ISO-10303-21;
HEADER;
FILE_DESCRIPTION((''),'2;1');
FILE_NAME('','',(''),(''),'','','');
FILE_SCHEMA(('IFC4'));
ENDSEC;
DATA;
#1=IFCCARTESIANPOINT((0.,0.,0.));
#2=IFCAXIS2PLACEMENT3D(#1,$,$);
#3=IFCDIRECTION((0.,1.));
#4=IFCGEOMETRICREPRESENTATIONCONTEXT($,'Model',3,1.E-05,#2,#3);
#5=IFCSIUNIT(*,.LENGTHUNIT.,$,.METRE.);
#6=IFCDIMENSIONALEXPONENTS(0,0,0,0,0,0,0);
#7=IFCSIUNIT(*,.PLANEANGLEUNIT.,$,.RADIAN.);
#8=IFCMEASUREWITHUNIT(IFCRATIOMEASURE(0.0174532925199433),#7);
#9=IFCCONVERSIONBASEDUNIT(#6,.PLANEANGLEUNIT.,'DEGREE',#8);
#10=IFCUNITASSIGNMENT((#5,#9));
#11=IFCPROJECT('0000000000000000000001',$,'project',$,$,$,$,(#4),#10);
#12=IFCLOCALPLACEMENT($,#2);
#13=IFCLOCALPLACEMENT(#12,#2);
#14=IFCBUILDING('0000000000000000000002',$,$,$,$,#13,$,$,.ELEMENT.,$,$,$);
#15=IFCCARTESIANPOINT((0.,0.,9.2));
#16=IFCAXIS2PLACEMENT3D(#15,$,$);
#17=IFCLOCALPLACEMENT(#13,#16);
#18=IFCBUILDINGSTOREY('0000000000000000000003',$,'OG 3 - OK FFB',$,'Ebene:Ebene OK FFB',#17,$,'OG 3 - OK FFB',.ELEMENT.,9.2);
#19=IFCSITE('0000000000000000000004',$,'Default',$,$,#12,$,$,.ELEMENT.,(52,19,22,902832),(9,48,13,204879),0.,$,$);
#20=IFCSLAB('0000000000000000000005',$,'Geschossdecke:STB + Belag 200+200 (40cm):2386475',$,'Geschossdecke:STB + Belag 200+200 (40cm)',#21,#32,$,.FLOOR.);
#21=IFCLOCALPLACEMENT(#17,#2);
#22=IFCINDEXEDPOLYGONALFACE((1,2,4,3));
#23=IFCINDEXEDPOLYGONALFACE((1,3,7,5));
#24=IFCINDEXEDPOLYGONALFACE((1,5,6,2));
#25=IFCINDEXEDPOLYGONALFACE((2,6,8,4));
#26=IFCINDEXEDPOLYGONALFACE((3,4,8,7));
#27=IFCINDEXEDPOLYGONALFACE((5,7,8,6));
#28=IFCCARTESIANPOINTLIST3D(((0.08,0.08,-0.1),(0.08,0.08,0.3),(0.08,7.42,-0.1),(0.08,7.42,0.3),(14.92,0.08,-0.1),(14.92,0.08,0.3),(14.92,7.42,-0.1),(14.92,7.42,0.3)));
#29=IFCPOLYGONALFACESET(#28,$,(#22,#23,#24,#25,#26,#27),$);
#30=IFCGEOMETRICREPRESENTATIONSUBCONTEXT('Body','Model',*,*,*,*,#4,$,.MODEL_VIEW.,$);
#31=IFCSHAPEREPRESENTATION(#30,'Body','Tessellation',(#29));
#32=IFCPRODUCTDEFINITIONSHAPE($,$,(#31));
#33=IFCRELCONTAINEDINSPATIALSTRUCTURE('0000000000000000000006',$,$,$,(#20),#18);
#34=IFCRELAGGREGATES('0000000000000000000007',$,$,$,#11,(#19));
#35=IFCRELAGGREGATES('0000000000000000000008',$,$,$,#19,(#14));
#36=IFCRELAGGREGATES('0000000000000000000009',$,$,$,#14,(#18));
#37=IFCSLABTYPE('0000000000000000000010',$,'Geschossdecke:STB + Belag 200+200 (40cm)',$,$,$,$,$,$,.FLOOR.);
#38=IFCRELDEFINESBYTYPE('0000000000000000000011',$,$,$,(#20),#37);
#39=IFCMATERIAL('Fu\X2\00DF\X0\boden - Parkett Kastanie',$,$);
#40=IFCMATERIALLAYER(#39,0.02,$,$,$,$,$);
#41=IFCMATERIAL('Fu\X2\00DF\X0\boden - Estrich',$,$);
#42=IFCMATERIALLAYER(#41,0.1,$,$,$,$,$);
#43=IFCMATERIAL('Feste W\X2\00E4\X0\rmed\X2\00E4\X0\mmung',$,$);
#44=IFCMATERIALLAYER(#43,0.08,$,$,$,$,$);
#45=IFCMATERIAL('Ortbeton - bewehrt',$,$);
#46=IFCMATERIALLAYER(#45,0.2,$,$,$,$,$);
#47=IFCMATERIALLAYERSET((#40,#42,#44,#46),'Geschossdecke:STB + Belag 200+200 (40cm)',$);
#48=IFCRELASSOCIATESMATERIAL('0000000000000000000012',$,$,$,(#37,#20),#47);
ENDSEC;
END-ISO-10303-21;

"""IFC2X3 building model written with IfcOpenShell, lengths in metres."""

from ifc_helpers import new_model, entity, si_unit, converted_unit, direction, frame, frame_2d, origin, place, context, subcontext, project, spatial, rectangle, extrude, material, layer, layer_set, layer_usage, type_object, element, save


model = new_model("IFC2X3")

# Units and contexts
model_context = context("Model", 3, precision=1e-05, world=origin(), true_north=direction((0.0, 1.0)))
body_context = subcontext(model_context, "Body", "Model", "MODEL_VIEW")
ifc_project = project(units=[si_unit("LENGTHUNIT", "METRE"), converted_unit("PLANEANGLEUNIT", "DEGREE", entity("IfcRatioMeasure", 0.0174532925199433), si_unit("PLANEANGLEUNIT", "RADIAN"), dimensions=[0, 0, 0, 0, 0, 0, 0])], contexts=[model_context])

# Site, building, storey
site_placement = place(None, frame((0.0, 0.0, 0.0)))
site = spatial("IfcSite", under=ifc_project, at=site_placement, Name="Default", CompositionType="ELEMENT", RefLatitude=(52, 19, 22, 902832), RefLongitude=(9, 48, 13, 204879), RefElevation=0.0)
building_placement = place(site_placement, origin())
building = spatial("IfcBuilding", under=site, at=building_placement, CompositionType="ELEMENT")
storey_placement = place(building_placement, frame((0.0, 0.0, 9.2)))
storey = spatial("IfcBuildingStorey", under=building, at=storey_placement, Name="OG 3 - OK FFB", ObjectType="Ebene:Ebene OK FFB", LongName="OG 3 - OK FFB", CompositionType="ELEMENT", Elevation=9.2)

# Slab
ifc_material_1 = material(Name="Fußboden - Parkett Kastanie")
ifc_layer_1 = layer(ifc_material_1, 0.02)
ifc_material_2 = material(Name="Fußboden - Estrich")
ifc_layer_2 = layer(ifc_material_2, 0.1)
ifc_material_3 = material(Name="Feste Wärmedämmung")
ifc_layer_3 = layer(ifc_material_3, 0.08)
ifc_material_4 = material(Name="Ortbeton - bewehrt")
ifc_layer_4 = layer(ifc_material_4, 0.2)
ifc_layer_set = layer_set([ifc_layer_1, ifc_layer_2, ifc_layer_3, ifc_layer_4], Name="Geschossdecke:STB + Belag 200+200 (40cm)")
ifc_layer_usage = layer_usage(ifc_layer_set, "AXIS3", "POSITIVE", 0.0)
slab_type = type_object("IfcSlabType", Name="Geschossdecke:STB + Belag 200+200 (40cm)", PredefinedType="FLOOR", material=ifc_layer_set)
slab_placement = place(storey_placement, origin())
element("IfcSlab", 1, at=slab_placement, inside=storey, type_object=slab_type, material=ifc_layer_usage, Name="Geschossdecke:STB + Belag 200+200 (40cm):2386475", ObjectType="Geschossdecke:STB + Belag 200+200 (40cm)", PredefinedType="FLOOR", context=body_context, shape_type="SweptSolid", body=[
    extrude(rectangle(XDim=7.34, YDim=14.84, at=frame_2d((0.0, 0.0), x_axis=(1.0, 0.0))), frame((7.5, 3.75, 0.3), z_axis=(0.0, 0.0, -1.0), x_axis=(0.0, 1.0, 0.0)), (0.0, 0.0, 1.0), 0.4),
])

save(model, "model.ifc")
